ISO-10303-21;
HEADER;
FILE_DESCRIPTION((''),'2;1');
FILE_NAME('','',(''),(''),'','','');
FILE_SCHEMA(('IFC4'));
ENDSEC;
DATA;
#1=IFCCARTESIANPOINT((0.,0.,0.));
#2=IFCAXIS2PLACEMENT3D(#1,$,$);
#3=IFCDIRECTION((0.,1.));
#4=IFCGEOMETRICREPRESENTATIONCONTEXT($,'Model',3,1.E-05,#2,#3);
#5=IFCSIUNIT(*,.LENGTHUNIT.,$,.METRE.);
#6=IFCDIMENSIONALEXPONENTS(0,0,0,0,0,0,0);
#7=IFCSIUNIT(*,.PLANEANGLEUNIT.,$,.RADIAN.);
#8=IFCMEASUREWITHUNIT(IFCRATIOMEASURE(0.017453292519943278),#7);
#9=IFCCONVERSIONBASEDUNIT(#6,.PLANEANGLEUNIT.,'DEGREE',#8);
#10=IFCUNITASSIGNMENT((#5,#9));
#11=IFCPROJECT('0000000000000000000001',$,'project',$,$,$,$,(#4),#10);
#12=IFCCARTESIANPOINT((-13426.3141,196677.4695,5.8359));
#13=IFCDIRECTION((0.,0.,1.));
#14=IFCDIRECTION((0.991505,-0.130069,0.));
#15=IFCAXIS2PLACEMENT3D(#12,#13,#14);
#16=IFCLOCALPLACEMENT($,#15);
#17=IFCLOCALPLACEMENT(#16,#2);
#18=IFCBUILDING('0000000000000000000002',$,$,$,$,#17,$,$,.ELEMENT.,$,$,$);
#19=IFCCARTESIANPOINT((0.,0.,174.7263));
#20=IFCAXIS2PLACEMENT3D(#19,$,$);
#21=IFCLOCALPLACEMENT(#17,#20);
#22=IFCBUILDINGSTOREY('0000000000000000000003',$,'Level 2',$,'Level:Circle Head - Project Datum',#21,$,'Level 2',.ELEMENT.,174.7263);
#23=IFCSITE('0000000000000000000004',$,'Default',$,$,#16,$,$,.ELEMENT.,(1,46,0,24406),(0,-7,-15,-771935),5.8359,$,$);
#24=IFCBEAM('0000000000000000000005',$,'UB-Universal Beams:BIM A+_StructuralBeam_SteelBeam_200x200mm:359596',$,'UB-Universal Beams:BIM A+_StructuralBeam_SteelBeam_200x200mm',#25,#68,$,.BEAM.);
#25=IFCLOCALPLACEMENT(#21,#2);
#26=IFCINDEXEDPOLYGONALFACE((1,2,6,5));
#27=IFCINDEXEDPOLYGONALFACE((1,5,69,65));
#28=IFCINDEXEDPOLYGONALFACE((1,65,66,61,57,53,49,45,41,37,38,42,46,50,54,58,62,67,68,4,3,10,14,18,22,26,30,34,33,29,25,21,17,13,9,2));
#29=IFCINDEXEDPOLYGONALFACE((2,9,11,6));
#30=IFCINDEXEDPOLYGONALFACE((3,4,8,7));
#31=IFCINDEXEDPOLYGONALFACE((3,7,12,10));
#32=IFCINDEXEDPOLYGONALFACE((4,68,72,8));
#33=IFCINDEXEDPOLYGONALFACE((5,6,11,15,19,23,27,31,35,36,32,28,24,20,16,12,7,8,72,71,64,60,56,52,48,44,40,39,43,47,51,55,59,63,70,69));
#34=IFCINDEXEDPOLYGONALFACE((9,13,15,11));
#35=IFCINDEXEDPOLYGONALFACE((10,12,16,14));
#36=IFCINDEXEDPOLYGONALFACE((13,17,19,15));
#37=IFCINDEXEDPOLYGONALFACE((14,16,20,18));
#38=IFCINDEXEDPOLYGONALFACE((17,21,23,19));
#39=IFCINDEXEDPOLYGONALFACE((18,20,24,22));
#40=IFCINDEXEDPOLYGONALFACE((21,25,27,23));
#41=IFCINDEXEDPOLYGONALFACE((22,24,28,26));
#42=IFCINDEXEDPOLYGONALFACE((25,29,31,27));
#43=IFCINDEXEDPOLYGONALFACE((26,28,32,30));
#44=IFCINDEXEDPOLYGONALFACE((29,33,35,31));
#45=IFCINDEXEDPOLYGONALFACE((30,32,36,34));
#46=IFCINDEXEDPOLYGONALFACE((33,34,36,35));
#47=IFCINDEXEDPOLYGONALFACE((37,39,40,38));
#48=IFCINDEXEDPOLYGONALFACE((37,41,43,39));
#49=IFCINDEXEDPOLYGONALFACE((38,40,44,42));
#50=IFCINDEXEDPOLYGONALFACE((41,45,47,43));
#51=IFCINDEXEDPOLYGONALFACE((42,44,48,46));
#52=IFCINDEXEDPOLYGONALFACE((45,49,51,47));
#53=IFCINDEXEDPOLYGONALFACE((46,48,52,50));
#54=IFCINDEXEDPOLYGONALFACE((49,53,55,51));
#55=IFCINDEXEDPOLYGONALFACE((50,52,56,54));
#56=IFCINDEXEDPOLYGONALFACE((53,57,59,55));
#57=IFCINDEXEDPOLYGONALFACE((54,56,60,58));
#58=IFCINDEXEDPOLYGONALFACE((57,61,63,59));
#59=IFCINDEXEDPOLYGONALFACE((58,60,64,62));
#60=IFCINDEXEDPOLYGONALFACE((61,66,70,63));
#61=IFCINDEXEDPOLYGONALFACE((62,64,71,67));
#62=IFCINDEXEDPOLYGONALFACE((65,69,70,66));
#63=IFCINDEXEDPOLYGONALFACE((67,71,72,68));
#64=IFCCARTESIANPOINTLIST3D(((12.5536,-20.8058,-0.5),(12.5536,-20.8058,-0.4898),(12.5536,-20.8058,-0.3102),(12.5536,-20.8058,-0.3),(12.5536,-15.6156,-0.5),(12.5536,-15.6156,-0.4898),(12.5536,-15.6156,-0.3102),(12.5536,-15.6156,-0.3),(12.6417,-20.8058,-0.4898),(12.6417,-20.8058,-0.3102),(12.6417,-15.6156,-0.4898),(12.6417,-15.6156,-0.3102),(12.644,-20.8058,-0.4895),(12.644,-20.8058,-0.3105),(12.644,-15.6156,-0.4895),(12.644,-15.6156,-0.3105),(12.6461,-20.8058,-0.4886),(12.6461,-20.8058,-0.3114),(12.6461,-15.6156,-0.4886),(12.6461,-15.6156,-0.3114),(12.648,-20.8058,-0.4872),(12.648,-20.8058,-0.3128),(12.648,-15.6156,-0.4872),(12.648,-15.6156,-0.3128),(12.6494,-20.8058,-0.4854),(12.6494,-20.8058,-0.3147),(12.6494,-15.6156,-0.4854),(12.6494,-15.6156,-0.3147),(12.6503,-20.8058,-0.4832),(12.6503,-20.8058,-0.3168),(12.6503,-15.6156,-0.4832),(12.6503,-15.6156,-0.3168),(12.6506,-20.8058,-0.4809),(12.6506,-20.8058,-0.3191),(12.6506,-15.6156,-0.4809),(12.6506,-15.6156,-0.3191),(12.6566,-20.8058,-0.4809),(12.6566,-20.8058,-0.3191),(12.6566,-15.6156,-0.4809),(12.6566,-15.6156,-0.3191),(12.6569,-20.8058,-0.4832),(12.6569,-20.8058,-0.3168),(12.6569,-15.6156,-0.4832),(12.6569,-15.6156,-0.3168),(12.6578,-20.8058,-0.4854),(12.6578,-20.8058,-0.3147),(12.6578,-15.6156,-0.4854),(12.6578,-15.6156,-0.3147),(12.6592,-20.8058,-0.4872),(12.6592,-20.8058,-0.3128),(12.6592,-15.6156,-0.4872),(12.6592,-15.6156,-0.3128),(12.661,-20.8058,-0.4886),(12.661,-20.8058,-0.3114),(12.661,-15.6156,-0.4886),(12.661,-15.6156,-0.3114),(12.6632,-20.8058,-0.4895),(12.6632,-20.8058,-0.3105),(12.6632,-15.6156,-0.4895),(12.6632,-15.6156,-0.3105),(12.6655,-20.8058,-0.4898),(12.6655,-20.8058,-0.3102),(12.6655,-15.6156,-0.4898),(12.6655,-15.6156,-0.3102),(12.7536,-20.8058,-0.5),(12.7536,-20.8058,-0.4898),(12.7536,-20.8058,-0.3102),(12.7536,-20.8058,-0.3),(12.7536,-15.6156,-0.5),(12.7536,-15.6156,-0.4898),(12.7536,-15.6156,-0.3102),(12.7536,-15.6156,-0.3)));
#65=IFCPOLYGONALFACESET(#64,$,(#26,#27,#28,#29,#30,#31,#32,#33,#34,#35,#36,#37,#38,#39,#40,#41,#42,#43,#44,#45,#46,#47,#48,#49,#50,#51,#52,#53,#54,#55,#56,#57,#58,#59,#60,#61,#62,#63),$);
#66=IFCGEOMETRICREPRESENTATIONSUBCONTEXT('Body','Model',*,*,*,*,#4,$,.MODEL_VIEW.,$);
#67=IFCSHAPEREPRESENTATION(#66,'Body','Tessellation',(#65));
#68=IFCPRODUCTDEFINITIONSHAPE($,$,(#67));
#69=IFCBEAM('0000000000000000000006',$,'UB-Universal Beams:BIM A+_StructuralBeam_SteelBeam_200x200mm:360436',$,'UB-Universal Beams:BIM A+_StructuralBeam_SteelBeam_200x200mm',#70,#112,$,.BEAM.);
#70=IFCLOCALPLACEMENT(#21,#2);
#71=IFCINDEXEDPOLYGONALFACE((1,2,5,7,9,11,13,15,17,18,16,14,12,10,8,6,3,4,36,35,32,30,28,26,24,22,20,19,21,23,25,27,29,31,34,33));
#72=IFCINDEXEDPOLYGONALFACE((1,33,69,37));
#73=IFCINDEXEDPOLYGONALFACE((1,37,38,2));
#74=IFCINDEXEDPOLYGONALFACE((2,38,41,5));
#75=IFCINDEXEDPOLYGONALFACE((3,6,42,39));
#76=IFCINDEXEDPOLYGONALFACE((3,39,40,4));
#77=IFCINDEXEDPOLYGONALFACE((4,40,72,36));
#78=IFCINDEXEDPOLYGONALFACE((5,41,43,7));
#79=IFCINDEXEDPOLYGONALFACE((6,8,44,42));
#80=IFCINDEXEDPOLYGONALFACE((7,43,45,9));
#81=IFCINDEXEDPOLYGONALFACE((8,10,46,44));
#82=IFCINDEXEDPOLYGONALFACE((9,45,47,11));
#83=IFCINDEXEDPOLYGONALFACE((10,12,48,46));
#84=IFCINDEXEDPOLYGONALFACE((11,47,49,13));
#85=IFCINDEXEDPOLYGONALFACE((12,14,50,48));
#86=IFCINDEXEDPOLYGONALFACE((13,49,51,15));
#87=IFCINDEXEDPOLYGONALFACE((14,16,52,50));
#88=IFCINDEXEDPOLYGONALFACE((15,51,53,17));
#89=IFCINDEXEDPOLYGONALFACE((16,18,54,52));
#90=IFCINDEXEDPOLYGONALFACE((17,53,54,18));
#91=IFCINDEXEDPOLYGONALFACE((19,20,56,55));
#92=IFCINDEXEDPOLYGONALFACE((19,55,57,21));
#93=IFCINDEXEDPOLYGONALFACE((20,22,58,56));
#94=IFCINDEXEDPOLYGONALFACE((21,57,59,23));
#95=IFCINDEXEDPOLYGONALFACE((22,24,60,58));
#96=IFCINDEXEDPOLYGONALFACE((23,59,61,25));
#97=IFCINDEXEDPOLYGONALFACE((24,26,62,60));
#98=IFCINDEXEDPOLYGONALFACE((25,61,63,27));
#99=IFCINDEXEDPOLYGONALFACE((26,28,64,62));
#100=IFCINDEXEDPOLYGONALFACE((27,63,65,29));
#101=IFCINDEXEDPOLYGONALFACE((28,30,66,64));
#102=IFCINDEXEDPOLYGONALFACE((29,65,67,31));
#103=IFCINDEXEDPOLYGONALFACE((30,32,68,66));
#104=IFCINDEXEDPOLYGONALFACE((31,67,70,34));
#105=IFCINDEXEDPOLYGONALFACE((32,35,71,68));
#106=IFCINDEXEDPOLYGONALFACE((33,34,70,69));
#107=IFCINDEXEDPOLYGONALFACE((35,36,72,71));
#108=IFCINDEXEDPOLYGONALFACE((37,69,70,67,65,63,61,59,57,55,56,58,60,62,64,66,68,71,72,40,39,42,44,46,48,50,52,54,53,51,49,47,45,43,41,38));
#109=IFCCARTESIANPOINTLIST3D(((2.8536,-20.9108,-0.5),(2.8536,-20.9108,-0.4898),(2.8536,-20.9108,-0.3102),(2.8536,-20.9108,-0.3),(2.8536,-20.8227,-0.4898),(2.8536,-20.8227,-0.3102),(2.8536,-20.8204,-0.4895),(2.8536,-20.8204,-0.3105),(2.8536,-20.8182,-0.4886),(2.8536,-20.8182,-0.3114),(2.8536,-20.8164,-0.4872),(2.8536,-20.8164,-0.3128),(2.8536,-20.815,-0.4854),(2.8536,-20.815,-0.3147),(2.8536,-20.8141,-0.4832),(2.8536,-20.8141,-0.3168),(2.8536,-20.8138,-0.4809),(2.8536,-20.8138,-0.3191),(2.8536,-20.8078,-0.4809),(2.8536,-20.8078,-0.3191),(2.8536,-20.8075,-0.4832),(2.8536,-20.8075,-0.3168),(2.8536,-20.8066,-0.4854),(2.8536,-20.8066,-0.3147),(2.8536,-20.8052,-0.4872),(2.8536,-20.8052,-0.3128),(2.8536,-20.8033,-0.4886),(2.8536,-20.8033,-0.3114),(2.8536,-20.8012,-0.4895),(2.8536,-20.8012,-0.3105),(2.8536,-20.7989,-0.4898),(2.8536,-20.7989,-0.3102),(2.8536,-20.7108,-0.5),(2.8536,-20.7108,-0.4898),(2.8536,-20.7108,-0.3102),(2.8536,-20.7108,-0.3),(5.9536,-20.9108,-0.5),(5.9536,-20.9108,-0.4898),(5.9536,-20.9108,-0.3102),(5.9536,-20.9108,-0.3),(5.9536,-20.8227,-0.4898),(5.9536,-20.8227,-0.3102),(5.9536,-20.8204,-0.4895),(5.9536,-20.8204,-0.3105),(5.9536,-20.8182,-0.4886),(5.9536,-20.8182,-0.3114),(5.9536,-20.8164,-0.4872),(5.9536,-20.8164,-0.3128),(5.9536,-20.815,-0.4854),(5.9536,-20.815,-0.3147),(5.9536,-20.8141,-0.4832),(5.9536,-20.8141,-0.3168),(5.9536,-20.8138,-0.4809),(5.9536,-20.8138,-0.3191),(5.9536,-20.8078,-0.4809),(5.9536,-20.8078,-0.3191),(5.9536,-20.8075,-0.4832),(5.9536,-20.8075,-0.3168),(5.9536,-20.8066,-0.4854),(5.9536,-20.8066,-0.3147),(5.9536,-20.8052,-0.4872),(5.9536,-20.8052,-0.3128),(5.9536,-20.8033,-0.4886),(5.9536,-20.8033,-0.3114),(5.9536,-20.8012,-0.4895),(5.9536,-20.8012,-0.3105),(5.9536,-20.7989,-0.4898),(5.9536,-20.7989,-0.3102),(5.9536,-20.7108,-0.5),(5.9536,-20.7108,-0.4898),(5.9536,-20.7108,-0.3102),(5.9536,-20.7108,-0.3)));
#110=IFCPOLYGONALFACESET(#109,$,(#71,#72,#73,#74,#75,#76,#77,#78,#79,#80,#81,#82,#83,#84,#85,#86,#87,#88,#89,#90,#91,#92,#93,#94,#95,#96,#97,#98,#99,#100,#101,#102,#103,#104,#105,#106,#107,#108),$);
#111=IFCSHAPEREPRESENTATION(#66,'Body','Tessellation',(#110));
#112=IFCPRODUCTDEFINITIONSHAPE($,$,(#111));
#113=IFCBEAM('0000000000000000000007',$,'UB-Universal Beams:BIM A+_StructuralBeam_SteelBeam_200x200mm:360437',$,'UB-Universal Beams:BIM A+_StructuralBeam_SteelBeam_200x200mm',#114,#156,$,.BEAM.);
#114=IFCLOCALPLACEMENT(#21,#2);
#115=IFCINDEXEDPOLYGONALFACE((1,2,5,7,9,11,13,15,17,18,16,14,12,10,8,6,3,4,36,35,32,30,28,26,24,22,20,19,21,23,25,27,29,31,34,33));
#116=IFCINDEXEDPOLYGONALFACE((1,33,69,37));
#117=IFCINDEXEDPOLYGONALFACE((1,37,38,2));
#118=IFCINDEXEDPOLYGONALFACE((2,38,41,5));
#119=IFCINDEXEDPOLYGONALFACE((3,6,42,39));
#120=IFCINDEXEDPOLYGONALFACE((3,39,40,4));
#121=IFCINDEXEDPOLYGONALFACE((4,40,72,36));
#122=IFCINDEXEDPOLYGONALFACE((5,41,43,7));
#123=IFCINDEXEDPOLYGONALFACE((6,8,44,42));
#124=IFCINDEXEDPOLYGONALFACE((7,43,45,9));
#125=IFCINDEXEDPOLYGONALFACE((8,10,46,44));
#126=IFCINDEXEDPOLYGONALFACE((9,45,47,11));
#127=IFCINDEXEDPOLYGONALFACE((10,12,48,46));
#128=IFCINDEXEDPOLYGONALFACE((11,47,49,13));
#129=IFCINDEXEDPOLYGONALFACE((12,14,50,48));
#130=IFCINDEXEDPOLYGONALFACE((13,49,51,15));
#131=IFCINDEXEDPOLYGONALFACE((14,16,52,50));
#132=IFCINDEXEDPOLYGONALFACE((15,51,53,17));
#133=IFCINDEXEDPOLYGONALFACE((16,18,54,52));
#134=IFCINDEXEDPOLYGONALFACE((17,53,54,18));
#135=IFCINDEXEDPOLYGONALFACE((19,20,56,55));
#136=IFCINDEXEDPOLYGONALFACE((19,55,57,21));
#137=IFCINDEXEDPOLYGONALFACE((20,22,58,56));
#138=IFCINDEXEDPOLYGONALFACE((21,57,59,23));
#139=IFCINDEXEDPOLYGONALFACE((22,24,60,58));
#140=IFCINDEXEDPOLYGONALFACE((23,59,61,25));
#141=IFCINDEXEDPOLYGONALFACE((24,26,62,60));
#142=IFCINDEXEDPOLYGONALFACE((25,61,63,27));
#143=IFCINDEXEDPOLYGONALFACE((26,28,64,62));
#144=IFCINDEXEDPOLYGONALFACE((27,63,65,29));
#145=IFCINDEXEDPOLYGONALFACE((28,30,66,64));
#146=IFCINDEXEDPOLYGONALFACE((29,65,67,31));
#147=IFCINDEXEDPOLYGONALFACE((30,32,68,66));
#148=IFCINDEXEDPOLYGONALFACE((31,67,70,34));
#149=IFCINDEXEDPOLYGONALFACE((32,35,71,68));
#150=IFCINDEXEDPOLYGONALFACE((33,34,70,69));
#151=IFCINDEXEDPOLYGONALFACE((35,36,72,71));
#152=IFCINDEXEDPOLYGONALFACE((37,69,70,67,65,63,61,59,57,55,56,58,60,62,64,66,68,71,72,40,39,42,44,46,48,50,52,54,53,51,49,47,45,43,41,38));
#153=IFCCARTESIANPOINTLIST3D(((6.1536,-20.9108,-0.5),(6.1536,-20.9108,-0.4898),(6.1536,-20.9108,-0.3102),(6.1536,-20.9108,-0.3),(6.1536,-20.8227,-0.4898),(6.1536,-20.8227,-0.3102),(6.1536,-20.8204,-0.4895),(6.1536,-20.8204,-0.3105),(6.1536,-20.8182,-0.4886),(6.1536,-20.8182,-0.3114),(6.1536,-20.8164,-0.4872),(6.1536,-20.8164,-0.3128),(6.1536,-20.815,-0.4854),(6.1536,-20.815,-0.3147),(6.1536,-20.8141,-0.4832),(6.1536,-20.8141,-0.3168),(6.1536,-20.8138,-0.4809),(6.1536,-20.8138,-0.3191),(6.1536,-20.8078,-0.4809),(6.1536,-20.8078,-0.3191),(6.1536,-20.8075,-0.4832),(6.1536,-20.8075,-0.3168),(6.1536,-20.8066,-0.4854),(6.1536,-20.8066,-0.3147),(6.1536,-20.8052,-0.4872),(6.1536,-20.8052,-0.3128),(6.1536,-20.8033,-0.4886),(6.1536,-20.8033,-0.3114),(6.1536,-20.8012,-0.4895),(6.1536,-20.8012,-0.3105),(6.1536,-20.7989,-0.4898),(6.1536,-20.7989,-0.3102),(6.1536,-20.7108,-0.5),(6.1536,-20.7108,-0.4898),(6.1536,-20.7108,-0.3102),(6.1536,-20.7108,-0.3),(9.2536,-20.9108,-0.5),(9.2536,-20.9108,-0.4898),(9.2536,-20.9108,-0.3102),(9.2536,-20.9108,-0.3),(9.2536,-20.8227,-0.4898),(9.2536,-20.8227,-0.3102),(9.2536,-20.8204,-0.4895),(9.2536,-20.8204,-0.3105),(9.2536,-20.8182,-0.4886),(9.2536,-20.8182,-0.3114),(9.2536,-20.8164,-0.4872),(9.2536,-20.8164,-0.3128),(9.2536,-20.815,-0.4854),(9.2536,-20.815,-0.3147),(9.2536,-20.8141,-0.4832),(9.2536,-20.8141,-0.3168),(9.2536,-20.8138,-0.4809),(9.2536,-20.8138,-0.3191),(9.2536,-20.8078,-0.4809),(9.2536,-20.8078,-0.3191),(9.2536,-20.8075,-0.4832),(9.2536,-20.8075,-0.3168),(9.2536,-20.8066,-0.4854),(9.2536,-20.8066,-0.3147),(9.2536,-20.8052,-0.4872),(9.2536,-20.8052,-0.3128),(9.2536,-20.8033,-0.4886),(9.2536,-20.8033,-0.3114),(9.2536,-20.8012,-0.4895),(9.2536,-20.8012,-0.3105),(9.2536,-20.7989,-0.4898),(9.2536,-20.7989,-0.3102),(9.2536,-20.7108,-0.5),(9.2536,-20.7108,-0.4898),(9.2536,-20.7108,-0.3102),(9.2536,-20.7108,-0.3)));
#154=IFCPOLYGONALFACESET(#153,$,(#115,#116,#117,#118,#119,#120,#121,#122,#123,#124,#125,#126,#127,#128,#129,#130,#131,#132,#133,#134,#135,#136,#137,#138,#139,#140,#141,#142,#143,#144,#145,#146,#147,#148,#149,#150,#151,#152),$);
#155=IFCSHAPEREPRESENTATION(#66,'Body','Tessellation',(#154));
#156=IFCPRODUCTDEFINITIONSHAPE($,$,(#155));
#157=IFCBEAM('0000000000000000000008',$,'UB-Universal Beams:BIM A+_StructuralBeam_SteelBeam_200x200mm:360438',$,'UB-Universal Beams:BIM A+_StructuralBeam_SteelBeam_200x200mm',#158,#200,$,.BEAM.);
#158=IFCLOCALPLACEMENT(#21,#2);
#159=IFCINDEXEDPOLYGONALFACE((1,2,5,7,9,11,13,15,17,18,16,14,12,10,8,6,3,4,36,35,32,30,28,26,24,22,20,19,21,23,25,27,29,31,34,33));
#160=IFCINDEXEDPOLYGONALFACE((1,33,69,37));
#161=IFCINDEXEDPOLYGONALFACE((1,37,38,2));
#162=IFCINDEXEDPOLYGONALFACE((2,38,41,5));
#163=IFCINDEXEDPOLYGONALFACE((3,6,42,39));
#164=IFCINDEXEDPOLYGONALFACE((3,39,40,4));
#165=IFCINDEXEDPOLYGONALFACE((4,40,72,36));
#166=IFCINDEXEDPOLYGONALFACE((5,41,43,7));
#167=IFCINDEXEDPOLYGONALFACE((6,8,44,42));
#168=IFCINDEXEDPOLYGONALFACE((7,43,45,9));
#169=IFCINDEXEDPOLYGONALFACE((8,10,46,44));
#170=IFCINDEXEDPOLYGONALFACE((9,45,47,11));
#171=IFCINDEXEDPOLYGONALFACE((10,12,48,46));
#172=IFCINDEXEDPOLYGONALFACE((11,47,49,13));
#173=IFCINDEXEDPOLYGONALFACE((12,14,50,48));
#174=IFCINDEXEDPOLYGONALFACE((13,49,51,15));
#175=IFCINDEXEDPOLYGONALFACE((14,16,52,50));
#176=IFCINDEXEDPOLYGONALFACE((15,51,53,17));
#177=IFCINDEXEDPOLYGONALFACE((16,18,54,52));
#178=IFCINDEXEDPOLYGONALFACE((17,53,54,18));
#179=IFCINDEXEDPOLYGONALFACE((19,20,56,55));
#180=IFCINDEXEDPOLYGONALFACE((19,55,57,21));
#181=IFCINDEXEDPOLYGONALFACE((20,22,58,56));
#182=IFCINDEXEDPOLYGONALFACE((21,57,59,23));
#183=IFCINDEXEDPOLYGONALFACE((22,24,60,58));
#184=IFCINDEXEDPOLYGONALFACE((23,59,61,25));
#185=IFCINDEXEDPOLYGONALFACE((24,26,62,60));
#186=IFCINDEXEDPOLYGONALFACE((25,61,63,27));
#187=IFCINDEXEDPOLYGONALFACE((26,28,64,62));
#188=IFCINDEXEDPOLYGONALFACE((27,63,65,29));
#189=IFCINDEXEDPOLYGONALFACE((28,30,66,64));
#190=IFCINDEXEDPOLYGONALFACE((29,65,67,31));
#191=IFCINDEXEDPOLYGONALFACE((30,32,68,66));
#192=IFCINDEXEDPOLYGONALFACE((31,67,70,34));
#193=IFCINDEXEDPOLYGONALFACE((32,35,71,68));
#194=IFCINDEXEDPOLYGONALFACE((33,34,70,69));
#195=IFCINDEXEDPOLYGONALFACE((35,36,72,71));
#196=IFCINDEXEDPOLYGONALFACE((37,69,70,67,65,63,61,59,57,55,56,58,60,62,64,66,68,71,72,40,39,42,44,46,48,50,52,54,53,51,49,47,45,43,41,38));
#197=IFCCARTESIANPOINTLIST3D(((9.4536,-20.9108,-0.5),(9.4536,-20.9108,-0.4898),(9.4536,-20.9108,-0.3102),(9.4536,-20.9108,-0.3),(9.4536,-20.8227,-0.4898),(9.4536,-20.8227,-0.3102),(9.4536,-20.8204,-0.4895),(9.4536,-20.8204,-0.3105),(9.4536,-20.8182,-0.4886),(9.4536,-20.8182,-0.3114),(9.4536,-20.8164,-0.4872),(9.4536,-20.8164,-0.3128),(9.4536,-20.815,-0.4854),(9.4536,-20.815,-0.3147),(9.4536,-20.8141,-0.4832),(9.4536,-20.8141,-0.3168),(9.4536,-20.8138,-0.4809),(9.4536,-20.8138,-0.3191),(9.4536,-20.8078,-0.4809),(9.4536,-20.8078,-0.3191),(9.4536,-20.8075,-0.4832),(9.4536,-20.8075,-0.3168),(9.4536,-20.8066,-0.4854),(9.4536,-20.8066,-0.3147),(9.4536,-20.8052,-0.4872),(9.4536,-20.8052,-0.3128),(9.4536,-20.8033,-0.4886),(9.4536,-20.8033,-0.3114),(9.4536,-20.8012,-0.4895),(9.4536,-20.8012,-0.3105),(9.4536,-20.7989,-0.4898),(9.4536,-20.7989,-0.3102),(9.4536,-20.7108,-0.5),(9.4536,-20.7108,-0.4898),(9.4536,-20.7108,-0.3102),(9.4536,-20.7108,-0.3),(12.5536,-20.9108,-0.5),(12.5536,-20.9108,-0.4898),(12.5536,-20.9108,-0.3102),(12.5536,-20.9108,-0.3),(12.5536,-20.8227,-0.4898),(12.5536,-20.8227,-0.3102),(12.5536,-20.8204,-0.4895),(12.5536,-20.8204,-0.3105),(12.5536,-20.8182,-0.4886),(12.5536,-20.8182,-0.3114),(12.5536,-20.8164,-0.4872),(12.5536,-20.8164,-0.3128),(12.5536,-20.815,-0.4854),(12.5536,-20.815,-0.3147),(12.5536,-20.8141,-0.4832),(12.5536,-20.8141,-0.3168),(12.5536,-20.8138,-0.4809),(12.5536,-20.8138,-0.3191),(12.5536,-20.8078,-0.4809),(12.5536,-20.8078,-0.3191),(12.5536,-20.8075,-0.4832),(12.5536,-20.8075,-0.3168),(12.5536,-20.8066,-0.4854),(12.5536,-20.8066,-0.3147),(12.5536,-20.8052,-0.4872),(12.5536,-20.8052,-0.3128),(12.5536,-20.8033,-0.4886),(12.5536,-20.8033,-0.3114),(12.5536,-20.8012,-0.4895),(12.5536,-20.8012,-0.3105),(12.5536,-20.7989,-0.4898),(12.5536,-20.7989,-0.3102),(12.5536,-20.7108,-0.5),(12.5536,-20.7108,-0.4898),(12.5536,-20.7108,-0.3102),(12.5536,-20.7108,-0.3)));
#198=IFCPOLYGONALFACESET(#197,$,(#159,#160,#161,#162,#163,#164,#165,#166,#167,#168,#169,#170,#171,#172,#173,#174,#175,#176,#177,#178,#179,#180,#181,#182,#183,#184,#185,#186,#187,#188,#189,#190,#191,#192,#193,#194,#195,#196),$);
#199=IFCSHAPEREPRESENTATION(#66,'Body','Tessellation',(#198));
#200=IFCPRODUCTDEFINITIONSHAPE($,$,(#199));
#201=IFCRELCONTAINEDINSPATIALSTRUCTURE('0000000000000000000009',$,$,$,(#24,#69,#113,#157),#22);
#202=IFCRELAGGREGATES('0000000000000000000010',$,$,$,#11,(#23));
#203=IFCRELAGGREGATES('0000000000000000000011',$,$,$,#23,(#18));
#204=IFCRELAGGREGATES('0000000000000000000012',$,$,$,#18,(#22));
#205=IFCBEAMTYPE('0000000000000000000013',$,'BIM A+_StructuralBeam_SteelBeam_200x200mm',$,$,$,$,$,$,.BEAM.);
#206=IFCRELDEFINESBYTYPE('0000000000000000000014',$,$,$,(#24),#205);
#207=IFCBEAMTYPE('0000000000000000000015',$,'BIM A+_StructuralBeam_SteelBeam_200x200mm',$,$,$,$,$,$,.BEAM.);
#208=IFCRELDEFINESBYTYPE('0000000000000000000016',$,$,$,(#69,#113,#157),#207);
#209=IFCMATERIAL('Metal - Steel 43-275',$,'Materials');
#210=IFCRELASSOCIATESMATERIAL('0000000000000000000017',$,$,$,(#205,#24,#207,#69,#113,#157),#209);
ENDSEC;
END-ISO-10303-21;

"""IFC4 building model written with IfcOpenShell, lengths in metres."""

from ifc_helpers import new_model, entity, si_unit, converted_unit, direction, frame, origin, place, context, subcontext, project, spatial, line, arc, indexed_curve, outline, extrude, source, transform, mapped, material, type_object, type_shapes, element, save


model = new_model("IFC4")

# Units and contexts
model_context = context("Model", 3, precision=1e-05, world=origin(), true_north=direction((0.0, 1.0)))
body_context = subcontext(model_context, "Body", "Model", "MODEL_VIEW")
ifc_project = project(units=[si_unit("LENGTHUNIT", "METRE"), converted_unit("PLANEANGLEUNIT", "DEGREE", entity("IfcRatioMeasure", 0.017453292519943278), si_unit("PLANEANGLEUNIT", "RADIAN"), dimensions=[0, 0, 0, 0, 0, 0, 0])], contexts=[model_context])

# Site, building, storey
site_placement = place(None, frame((-13426.3141, 196677.4695, 5.8359), z_axis=(0.0, 0.0, 1.0), x_axis=(0.991505, -0.130069, 0.0)))
site = spatial("IfcSite", under=ifc_project, at=site_placement, Name="Default", CompositionType="ELEMENT", RefLatitude=(1, 46, 0, 24406), RefLongitude=(0, -7, -15, -771935), RefElevation=5.8359)
building_placement = place(site_placement, origin())
building = spatial("IfcBuilding", under=site, at=building_placement, CompositionType="ELEMENT")
storey_placement = place(building_placement, frame((0.0, 0.0, 174.7263)))
storey = spatial("IfcBuildingStorey", under=building, at=storey_placement, Name="Level 2", ObjectType="Level:Circle Head - Project Datum", LongName="Level 2", CompositionType="ELEMENT", Elevation=174.7263)

# Beams
ifc_material_1 = material(Name="Metal - Steel 43-275", Category="Materials")
beam_type_1 = type_object("IfcBeamType", Name="BIM A+_StructuralBeam_SteelBeam_200x200mm", PredefinedType="BEAM", material=ifc_material_1)
shared_shape_1 = source(origin(), body_context, "Body", "SweptSolid", [
    extrude(outline(indexed_curve([(-0.1, -0.1), (-0.0898, -0.1), (-0.0898, -0.0119), (-0.0872, -0.0056), (-0.0809, -0.003), (0.0809, -0.003), (0.0872, -0.0056), (0.0898, -0.0119), (0.0898, -0.1), (0.1, -0.1), (0.1, 0.1), (0.0898, 0.1), (0.0898, 0.0119), (0.0872, 0.0056), (0.0809, 0.003), (-0.0809, 0.003), (-0.0872, 0.0056), (-0.0898, 0.0119), (-0.0898, 0.1), (-0.1, 0.1)], segments=[line(1, 2, 3), arc(3, 4, 5), line(5, 6), arc(6, 7, 8), line(8, 9, 10, 11, 12, 13), arc(13, 14, 15), line(15, 16), arc(16, 17, 18), line(18, 19, 20, 1)], self_intersect=False)), frame((-2.5452, 0.0, 0.0), z_axis=(1.0, 0.0, 0.0), x_axis=(0.0, 0.0, -1.0)), (0.0, 0.0, 1.0), 5.1902),
])
type_shapes(beam_type_1, [shared_shape_1])
beam_placement = place(storey_placement, frame((12.6536, -18.1608, -0.4), z_axis=(0.0, 0.0, 1.0), x_axis=(0.0, -1.0, 0.0)))
element("IfcBeam", 1, at=beam_placement, inside=storey, type_object=beam_type_1, material=ifc_material_1, Name="UB-Universal Beams:BIM A+_StructuralBeam_SteelBeam_200x200mm:359596", ObjectType="UB-Universal Beams:BIM A+_StructuralBeam_SteelBeam_200x200mm", PredefinedType="BEAM", context=body_context, shape_type="MappedRepresentation", body=[
    mapped(shared_shape_1, transform((0.0, 0.0, 0.0), scale=1.0)),
])
beam_type_2 = type_object("IfcBeamType", Name="BIM A+_StructuralBeam_SteelBeam_200x200mm", PredefinedType="BEAM", material=ifc_material_1)
shared_shape_2 = source(origin(), body_context, "Body", "SweptSolid", [
    extrude(outline(indexed_curve([(-0.1, -0.1), (-0.0898, -0.1), (-0.0898, -0.0119), (-0.0872, -0.0056), (-0.0809, -0.003), (0.0809, -0.003), (0.0872, -0.0056), (0.0898, -0.0119), (0.0898, -0.1), (0.1, -0.1), (0.1, 0.1), (0.0898, 0.1), (0.0898, 0.0119), (0.0872, 0.0056), (0.0809, 0.003), (-0.0809, 0.003), (-0.0872, 0.0056), (-0.0898, 0.0119), (-0.0898, 0.1), (-0.1, 0.1)], segments=[line(1, 2, 3), arc(3, 4, 5), line(5, 6), arc(6, 7, 8), line(8, 9, 10, 11, 12, 13), arc(13, 14, 15), line(15, 16), arc(16, 17, 18), line(18, 19, 20, 1)], self_intersect=False)), frame((-0.3639, 0.0, 0.0), z_axis=(1.0, 0.0, 0.0), x_axis=(0.0, 0.0, -1.0)), (0.0, 0.0, 1.0), 3.1),
])
type_shapes(beam_type_2, [shared_shape_2])
for number, where, z_axis, x_axis, name in (
    (2, (5.5897, -20.8108, -0.4), (0.0, 0.0, 1.0), (-1.0, 0.0, 0.0), "UB-Universal Beams:BIM A+_StructuralBeam_SteelBeam_200x200mm:360436"),
    (3, (8.8897, -20.8108, -0.4), (0.0, 0.0, 1.0), (-1.0, 0.0, 0.0), "UB-Universal Beams:BIM A+_StructuralBeam_SteelBeam_200x200mm:360437"),
    (4, (12.1897, -20.8108, -0.4), (0.0, 0.0, 1.0), (-1.0, 0.0, 0.0), "UB-Universal Beams:BIM A+_StructuralBeam_SteelBeam_200x200mm:360438"),
):
    element("IfcBeam", number, at=place(storey_placement, frame(where, z_axis=z_axis, x_axis=x_axis)), inside=storey, type_object=beam_type_2, material=ifc_material_1, Name=name, ObjectType="UB-Universal Beams:BIM A+_StructuralBeam_SteelBeam_200x200mm", PredefinedType="BEAM", context=body_context, shape_type="MappedRepresentation", body=[
        mapped(shared_shape_2, transform((0.0, 0.0, 0.0), scale=1.0)),
    ])

save(model, "model.ifc")
